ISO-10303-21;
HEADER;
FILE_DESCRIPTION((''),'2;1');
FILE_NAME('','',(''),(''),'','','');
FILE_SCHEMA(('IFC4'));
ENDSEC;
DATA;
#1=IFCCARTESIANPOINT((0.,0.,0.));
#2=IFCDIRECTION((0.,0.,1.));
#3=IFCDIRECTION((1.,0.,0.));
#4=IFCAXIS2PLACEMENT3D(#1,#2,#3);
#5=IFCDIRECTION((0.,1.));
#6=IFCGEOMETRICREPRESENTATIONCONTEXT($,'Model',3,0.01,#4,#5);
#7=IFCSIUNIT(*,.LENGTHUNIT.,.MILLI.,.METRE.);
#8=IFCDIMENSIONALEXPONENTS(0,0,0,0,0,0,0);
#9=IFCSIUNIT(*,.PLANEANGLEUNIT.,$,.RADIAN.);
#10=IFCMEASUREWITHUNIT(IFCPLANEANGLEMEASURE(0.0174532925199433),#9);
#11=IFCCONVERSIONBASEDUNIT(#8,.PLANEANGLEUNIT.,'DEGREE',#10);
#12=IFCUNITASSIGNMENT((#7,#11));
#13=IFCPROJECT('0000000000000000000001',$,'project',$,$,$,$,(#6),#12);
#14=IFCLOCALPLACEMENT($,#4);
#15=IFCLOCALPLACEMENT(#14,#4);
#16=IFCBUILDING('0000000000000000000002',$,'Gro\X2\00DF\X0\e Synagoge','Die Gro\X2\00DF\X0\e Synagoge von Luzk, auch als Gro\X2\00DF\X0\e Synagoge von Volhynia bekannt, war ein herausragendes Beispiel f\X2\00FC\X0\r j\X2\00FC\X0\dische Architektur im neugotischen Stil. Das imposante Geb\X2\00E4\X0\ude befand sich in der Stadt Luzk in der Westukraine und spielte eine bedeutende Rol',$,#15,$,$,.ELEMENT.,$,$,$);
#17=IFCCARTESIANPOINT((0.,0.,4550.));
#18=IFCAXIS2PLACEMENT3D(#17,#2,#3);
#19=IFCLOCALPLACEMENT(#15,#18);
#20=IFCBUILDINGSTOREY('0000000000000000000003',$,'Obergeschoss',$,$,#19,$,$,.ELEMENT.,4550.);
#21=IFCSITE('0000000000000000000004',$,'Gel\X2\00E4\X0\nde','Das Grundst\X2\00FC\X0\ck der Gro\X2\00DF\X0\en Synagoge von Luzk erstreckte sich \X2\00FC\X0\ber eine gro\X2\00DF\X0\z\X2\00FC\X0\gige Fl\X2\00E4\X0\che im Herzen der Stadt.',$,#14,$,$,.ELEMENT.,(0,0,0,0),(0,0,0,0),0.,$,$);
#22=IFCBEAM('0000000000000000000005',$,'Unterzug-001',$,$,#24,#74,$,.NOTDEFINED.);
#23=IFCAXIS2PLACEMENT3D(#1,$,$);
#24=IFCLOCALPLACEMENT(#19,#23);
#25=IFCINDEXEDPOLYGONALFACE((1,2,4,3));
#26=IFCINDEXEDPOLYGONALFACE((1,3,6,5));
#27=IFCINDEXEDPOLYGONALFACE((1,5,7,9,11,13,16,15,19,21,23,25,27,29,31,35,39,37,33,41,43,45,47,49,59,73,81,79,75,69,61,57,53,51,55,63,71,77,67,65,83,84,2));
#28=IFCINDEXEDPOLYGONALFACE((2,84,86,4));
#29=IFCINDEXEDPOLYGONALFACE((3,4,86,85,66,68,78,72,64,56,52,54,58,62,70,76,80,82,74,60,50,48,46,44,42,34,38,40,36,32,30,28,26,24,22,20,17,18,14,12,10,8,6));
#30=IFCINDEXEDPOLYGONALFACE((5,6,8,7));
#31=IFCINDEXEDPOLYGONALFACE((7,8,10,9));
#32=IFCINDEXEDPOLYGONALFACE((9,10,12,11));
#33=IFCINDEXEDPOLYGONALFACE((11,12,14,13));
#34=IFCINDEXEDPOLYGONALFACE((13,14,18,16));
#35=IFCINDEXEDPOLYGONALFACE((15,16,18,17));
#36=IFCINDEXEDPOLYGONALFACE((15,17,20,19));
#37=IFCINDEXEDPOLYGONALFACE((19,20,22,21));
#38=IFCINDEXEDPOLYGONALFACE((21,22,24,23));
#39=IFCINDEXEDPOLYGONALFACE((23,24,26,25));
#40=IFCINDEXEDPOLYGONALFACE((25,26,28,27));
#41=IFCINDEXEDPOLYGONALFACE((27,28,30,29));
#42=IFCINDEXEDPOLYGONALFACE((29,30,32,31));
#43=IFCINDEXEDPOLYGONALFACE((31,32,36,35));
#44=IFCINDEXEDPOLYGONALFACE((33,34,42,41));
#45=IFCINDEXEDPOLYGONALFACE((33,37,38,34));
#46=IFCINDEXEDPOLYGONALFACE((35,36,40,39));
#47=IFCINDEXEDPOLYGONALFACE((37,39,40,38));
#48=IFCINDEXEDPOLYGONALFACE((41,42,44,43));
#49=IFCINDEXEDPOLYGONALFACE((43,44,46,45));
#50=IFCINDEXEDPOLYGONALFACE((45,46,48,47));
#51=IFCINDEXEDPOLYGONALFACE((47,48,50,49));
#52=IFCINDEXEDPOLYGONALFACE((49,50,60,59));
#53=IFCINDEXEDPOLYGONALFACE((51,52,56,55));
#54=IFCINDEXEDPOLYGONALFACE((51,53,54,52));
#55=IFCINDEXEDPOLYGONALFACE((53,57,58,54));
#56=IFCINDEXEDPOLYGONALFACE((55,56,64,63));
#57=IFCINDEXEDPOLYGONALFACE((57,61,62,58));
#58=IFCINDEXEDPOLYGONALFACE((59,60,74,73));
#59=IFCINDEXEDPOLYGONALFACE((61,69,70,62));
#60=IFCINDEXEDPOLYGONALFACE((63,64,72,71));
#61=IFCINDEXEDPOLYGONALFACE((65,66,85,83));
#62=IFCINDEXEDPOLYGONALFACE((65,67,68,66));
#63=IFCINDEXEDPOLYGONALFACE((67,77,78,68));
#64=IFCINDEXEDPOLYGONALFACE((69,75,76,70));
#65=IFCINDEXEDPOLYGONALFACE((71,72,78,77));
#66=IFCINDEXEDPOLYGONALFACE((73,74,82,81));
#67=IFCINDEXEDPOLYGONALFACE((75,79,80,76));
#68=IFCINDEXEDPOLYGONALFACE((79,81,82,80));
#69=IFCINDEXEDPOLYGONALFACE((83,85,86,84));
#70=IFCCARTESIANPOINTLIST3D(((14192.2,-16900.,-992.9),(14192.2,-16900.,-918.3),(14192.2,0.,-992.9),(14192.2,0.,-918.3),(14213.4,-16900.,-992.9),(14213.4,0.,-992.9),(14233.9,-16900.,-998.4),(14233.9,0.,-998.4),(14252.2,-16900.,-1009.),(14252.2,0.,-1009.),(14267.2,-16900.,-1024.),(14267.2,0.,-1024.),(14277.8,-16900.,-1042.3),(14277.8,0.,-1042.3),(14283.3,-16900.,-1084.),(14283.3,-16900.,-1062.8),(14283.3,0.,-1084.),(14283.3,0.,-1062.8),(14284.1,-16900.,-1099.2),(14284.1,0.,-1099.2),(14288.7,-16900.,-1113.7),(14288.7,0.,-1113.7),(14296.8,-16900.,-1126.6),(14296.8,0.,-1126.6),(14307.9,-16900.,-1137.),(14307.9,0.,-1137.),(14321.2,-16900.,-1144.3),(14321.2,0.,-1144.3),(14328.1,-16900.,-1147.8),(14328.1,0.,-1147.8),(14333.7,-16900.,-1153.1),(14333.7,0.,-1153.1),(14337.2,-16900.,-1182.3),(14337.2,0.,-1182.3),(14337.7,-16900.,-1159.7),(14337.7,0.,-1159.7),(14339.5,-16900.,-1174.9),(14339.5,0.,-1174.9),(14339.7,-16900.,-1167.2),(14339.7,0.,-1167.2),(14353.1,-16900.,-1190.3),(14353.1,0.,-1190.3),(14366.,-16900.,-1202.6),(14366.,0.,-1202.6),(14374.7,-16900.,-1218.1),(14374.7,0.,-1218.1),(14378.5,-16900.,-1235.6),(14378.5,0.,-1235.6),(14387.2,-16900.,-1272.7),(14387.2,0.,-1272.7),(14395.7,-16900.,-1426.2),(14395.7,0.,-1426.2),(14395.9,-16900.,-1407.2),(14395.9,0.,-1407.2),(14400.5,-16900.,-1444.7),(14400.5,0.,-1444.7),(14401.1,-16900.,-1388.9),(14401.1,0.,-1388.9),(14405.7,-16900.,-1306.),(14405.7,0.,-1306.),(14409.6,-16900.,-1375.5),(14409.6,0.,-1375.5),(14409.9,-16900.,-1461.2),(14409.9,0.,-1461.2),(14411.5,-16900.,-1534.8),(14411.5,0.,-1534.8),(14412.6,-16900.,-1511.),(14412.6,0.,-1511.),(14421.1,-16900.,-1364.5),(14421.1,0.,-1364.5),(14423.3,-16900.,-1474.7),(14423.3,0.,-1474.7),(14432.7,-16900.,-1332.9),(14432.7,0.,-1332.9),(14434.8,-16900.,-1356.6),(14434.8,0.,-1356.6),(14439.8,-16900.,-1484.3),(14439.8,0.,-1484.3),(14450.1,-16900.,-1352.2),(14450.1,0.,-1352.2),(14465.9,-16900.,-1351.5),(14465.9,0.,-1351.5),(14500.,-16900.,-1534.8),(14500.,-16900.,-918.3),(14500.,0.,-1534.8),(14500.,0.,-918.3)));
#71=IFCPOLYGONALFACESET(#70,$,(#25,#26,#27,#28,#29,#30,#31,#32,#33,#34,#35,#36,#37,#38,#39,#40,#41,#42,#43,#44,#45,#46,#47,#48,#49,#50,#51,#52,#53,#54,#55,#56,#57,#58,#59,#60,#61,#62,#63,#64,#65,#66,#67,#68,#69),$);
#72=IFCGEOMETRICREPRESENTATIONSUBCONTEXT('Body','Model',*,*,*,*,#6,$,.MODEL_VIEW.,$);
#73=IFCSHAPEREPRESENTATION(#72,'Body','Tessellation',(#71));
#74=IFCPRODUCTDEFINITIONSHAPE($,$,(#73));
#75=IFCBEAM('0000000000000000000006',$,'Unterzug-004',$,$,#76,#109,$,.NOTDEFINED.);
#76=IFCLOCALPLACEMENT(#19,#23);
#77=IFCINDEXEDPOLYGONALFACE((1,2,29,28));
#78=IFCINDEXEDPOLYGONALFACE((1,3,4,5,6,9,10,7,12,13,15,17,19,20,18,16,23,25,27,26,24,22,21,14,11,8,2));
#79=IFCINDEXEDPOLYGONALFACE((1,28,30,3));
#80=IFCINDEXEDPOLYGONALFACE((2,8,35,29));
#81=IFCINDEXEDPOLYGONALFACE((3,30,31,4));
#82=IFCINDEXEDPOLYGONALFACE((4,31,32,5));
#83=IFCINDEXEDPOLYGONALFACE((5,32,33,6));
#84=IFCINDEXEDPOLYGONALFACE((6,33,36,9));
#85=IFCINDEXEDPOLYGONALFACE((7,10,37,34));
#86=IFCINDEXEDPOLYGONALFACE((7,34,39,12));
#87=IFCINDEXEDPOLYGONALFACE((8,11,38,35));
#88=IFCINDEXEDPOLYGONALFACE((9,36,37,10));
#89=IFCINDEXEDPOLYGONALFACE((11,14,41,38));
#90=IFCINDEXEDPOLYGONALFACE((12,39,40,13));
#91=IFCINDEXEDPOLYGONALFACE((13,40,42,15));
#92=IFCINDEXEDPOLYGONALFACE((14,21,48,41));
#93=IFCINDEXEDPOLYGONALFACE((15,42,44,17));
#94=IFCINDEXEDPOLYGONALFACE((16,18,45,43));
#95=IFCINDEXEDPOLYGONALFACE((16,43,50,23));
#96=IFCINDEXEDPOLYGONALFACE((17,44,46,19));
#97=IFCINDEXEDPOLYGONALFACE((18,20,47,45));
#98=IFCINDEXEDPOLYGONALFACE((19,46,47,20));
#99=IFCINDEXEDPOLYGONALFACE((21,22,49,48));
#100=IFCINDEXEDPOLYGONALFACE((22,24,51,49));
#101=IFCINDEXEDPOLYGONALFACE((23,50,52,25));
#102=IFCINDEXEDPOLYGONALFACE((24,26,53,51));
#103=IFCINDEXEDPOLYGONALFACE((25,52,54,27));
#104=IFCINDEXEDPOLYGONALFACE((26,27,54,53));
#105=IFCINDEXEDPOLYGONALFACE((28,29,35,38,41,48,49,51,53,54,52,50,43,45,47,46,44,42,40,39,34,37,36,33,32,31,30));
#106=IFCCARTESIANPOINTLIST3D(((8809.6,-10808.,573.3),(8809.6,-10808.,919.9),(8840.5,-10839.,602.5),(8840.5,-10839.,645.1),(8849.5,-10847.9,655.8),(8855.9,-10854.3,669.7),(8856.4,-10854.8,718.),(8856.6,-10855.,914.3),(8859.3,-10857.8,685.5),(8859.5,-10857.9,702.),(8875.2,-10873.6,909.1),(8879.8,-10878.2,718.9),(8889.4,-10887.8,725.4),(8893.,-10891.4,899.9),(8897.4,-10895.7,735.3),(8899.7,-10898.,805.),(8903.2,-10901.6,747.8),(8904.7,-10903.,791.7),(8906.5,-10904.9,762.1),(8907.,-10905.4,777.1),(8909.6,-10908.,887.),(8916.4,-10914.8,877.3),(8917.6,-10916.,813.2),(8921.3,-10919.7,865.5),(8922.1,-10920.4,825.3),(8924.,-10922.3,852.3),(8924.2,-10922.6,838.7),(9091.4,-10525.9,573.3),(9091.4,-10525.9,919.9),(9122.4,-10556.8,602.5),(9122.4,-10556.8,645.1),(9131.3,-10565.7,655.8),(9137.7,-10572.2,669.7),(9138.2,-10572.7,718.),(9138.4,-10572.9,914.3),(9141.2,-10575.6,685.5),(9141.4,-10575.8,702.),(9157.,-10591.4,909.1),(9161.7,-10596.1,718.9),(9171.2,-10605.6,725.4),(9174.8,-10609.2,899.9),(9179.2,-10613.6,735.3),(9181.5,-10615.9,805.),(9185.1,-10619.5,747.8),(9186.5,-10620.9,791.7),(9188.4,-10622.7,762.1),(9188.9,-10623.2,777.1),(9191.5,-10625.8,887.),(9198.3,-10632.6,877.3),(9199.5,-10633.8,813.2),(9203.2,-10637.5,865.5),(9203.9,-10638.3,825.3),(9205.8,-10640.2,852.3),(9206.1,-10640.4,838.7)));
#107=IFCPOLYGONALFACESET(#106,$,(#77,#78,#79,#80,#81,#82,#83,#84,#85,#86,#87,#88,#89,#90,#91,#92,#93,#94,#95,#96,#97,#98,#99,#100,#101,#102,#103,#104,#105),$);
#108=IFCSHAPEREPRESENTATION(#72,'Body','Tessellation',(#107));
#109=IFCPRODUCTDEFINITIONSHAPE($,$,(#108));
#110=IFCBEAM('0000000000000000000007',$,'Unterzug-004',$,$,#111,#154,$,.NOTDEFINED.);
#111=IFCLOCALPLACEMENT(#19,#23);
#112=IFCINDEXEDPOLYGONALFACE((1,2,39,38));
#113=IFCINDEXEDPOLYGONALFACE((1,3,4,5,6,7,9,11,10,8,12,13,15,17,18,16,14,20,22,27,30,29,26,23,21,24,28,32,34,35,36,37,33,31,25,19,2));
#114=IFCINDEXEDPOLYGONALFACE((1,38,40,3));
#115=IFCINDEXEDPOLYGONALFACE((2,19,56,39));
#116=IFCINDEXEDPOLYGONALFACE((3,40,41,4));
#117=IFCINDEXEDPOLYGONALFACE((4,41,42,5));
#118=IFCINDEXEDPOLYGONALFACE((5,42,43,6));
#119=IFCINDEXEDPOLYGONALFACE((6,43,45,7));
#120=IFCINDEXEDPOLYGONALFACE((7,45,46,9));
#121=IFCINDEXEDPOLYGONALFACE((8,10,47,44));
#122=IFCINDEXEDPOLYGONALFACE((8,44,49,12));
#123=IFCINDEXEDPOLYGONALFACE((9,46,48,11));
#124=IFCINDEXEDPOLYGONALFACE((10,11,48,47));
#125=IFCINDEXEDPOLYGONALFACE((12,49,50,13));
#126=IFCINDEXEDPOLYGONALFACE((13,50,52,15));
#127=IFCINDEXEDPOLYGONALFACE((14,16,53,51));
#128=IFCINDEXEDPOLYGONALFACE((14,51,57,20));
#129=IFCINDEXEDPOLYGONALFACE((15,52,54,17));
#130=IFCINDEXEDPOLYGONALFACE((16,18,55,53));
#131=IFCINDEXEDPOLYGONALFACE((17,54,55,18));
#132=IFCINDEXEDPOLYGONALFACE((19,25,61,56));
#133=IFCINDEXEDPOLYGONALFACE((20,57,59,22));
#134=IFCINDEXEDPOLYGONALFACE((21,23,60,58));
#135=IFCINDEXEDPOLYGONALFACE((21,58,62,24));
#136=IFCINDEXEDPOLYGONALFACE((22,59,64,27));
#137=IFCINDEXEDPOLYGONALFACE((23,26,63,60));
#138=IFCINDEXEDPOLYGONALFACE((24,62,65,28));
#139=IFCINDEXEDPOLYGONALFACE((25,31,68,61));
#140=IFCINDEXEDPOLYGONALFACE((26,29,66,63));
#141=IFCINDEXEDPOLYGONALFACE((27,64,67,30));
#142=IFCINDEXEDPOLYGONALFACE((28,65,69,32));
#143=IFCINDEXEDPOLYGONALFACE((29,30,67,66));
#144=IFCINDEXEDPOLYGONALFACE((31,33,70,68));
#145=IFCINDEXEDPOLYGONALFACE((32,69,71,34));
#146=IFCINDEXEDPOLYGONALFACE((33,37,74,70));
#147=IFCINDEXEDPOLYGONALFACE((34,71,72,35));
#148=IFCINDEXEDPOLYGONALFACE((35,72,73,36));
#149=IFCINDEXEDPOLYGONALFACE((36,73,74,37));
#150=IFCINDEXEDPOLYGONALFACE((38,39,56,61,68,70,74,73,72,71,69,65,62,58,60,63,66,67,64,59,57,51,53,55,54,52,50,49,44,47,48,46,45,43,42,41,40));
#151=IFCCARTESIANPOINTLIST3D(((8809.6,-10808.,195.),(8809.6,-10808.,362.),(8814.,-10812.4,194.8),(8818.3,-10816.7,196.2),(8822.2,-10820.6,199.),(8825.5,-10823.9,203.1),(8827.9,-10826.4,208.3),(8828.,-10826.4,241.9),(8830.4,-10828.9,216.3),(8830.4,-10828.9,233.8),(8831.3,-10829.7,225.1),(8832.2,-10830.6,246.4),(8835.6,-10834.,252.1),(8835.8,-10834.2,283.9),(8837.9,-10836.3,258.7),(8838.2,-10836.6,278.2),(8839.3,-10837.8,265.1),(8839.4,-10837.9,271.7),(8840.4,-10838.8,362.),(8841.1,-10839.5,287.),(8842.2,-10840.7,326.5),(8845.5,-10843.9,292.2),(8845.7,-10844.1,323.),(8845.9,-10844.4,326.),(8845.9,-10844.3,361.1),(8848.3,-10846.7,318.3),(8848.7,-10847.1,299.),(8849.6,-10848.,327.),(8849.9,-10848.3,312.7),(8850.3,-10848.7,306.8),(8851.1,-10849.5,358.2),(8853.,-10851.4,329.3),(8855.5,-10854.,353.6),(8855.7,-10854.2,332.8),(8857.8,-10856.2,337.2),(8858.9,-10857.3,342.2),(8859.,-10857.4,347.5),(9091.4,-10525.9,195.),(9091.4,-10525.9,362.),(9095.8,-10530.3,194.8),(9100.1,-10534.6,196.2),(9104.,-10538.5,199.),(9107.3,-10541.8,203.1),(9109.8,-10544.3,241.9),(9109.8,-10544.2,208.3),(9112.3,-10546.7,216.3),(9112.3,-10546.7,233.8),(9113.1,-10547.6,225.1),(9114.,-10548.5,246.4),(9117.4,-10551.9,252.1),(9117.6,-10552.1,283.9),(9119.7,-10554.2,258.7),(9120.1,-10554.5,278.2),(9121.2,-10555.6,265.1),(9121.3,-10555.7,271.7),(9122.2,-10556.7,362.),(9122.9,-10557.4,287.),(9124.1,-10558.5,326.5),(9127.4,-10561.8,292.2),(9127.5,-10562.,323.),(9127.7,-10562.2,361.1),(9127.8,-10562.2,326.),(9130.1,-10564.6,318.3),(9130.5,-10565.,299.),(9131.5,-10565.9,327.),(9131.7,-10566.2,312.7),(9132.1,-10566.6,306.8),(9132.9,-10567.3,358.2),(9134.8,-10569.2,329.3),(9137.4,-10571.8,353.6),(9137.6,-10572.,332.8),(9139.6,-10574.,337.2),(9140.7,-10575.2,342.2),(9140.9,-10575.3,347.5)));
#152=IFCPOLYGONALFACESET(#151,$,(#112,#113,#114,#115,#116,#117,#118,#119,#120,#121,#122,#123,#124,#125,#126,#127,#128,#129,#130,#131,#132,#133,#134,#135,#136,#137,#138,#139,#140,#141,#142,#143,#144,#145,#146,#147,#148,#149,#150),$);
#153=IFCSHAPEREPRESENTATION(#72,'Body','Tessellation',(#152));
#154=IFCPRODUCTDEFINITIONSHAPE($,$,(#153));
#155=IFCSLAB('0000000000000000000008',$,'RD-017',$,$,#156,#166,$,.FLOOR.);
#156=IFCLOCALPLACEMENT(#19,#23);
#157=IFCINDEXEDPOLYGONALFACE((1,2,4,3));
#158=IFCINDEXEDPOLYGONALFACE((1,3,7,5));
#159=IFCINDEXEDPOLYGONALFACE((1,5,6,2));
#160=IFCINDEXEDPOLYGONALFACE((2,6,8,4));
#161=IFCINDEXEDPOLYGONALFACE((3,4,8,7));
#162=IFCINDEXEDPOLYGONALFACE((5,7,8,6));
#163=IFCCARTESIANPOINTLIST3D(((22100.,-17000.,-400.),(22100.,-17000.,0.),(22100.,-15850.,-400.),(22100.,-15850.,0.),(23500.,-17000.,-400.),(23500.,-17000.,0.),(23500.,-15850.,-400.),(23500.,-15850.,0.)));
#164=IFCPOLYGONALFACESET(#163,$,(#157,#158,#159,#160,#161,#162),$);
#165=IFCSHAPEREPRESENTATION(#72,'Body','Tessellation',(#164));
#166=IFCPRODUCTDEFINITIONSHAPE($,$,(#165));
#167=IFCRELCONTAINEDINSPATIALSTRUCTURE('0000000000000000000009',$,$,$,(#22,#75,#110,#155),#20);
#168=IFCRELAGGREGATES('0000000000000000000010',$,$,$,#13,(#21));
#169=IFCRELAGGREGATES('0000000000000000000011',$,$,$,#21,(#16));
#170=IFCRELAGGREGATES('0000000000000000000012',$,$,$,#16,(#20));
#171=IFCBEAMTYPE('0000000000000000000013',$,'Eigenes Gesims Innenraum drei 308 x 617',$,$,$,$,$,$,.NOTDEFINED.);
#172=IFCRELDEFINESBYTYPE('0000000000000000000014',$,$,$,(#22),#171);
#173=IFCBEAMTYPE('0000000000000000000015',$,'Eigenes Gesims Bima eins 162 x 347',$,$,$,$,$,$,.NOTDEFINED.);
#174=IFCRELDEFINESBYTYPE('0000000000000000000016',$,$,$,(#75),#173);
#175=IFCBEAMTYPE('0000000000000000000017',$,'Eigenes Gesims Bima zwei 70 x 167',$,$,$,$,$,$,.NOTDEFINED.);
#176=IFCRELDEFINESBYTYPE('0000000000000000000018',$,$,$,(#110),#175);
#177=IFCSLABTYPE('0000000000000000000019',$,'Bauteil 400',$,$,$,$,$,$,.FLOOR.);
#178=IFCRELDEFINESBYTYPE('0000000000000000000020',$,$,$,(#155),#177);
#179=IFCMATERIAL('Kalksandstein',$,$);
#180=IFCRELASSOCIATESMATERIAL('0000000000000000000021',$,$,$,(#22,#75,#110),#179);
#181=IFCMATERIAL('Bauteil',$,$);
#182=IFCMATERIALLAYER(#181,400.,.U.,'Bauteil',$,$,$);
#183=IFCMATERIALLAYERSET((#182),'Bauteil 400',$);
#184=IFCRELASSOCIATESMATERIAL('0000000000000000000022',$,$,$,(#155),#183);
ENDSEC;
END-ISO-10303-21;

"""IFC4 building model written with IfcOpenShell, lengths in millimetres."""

from ifc_helpers import new_model, entity, si_unit, converted_unit, direction, frame, origin_with_axes, place, context, subcontext, project, spatial, line, arc, indexed_curve, outline, extrude, material, layer, layer_set, layer_usage, material_profile, profile_set, type_object, element, save


model = new_model("IFC4")

# Units and contexts
model_context = context("Model", 3, precision=0.01, world=origin_with_axes(), true_north=direction((0.0, 1.0)))
body_context = subcontext(model_context, "Body", "Model", "MODEL_VIEW")
ifc_project = project(units=[si_unit("LENGTHUNIT", "METRE", prefix="MILLI"), converted_unit("PLANEANGLEUNIT", "DEGREE", entity("IfcPlaneAngleMeasure", 0.0174532925199433), si_unit("PLANEANGLEUNIT", "RADIAN"), dimensions=[0, 0, 0, 0, 0, 0, 0])], contexts=[model_context])

# Site, building, storey
site_placement = place(None, origin_with_axes())
site = spatial("IfcSite", under=ifc_project, at=site_placement, Name="Gelände", Description="Das Grundstück der Großen Synagoge von Luzk erstreckte sich über eine großzügige Fläche im Herzen der Stadt.", CompositionType="ELEMENT", RefLatitude=(0, 0, 0, 0), RefLongitude=(0, 0, 0, 0), RefElevation=0.0)
building_placement = place(site_placement, origin_with_axes())
building = spatial("IfcBuilding", under=site, at=building_placement, Name="Große Synagoge", Description="Die Große Synagoge von Luzk, auch als Große Synagoge von Volhynia bekannt, war ein herausragendes Beispiel für jüdische Architektur im neugotischen Stil. Das imposante Gebäude befand sich in der Stadt Luzk in der Westukraine und spielte eine bedeutende Rol", CompositionType="ELEMENT")
storey_placement = place(building_placement, frame((0.0, 0.0, 4550.0), z_axis=(0.0, 0.0, 1.0), x_axis=(1.0, 0.0, 0.0)))
storey = spatial("IfcBuildingStorey", under=building, at=storey_placement, Name="Obergeschoss", CompositionType="ELEMENT", Elevation=4550.0)

# Beams
ifc_material_1 = material(Name="Kalksandstein")
ifc_material_profile_1 = material_profile(ifc_material_1, outline(indexed_curve([(121.5, -317.3), (134.0, -284.3), (162.8, -264.0), (162.3, -241.4), (178.8, -226.0), (207.7, -202.1), (216.7, -165.7), (239.8, -97.7), (307.8, -74.6), (307.8, 0.0), (0.0, 0.0), (0.0, -616.6), (88.5, -616.6), (87.4, -592.7), (60.2, -566.0), (99.5, -526.4), (98.9, -470.6), (72.3, -441.9), (34.1, -433.2), (94.3, -387.7)], segments=[arc(1, 2, 3), arc(3, 4, 5), arc(5, 6, 7), arc(7, 8, 9), line(9, 10, 11, 12, 13, 14, 15), arc(15, 16, 17), arc(17, 18, 19), arc(19, 20, 1)])), Name="Kalksandstein")
ifc_profile_set_1 = profile_set([ifc_material_profile_1], Name="Eigenes Gesims Innenraum drei")
beam_type_1 = type_object("IfcBeamType", Name="Eigenes Gesims Innenraum drei 308 x 617", PredefinedType="NOTDEFINED")
beam_1_placement = place(storey_placement, frame((14500.0, -16900.0, -918.3), z_axis=(0.0, 0.0, 1.0), x_axis=(1.0, 0.0, 0.0)))
element("IfcBeam", 1, at=beam_1_placement, inside=storey, type_object=beam_type_1, material=ifc_profile_set_1, Name="Unterzug-001", PredefinedType="NOTDEFINED", context=body_context, shape_type="SweptSolid", body=[
    extrude(outline(indexed_curve([(121.5, -317.3), (134.0, -284.3), (162.8, -264.0), (162.3, -241.4), (178.8, -226.0), (207.7, -202.1), (216.7, -165.7), (239.8, -97.7), (307.8, -74.6), (307.8, 0.0), (0.0, 0.0), (0.0, -616.6), (88.5, -616.6), (87.4, -592.7), (60.2, -566.0), (99.5, -526.4), (98.9, -470.6), (72.3, -441.9), (34.1, -433.2), (94.3, -387.7)], segments=[arc(1, 2, 3), arc(3, 4, 5), arc(5, 6, 7), arc(7, 8, 9), line(9, 10, 11, 12, 13, 14, 15), arc(15, 16, 17), arc(17, 18, 19), arc(19, 20, 1)])), frame((0.0, 16900.0, 0.0), z_axis=(0.0, 1.0, 0.0), x_axis=(-1.0, 0.0, 0.0)), (0.0, 0.0, -1.0), 16900.0),
])
ifc_material_profile_2 = material_profile(ifc_material_1, outline(indexed_curve([(127.4, -114.9), (152.7, -106.7), (161.7, -67.6), (141.4, -32.9), (105.5, -14.9), (66.5, -5.6), (0.0, 0.0), (0.0, -346.6), (43.7, -317.4), (43.7, -274.8), (68.5, -242.5), (66.2, -201.9), (99.3, -201.0), (135.2, -165.1)], segments=[line(1, 2), arc(2, 3, 4), arc(4, 5, 6), line(6, 7, 8, 9, 10), arc(10, 11, 12), line(12, 13), arc(13, 14, 1)])), Name="Kalksandstein")
ifc_profile_set_2 = profile_set([ifc_material_profile_2], Name="Eigenes Gesims Bima eins")
beam_type_2 = type_object("IfcBeamType", Name="Eigenes Gesims Bima eins 162 x 347", PredefinedType="NOTDEFINED")
beam_2_placement = place(storey_placement, frame((8809.6, -10808.0, 919.9), z_axis=(0.0, 0.0, 1.0), x_axis=(0.707468, -0.706745, 0.0)))
element("IfcBeam", 2, at=beam_2_placement, inside=storey, type_object=beam_type_2, material=ifc_profile_set_2, Name="Unterzug-004", PredefinedType="NOTDEFINED", context=body_context, shape_type="SweptSolid", body=[
    extrude(outline(indexed_curve([(127.4, -114.9), (152.7, -106.7), (161.7, -67.6), (141.4, -32.9), (105.5, -14.9), (66.5, -5.6), (0.0, 0.0), (0.0, -346.6), (43.7, -317.4), (43.7, -274.8), (68.5, -242.5), (66.2, -201.9), (99.3, -201.0), (135.2, -165.1)], segments=[line(1, 2), arc(2, 3, 4), arc(4, 5, 6), line(6, 7, 8, 9, 10), arc(10, 11, 12), line(12, 13), arc(13, 14, 1)])), frame((0.0, 398.8, 0.0), z_axis=(0.0, -1.0, 0.0), x_axis=(1.0, 0.0, 0.0)), (0.0, 0.0, 1.0), 398.8),
])
ifc_material_profile_3 = material_profile(ifc_material_1, outline(indexed_curve([(40.0, -103.3), (42.2, -90.2), (37.0, -78.1), (50.8, -69.8), (57.6, -55.2), (54.7, -43.7), (46.2, -35.5), (63.4, -31.1), (69.9, -14.5), (58.6, -3.7), (43.5, 0.0), (0.0, 0.0), (0.0, -167.0), (15.1, -164.6), (26.0, -153.7), (30.7, -136.9), (26.0, -120.0), (34.5, -112.9)], segments=[arc(1, 2, 3), arc(3, 4, 5), arc(5, 6, 7), arc(7, 8, 9), arc(9, 10, 11), line(11, 12, 13), arc(13, 14, 15), arc(15, 16, 17), arc(17, 18, 1)])), Name="Kalksandstein")
ifc_profile_set_3 = profile_set([ifc_material_profile_3], Name="Eigenes Gesims Bima zwei")
beam_type_3 = type_object("IfcBeamType", Name="Eigenes Gesims Bima zwei 70 x 167", PredefinedType="NOTDEFINED")
beam_3_placement = place(storey_placement, frame((8809.6, -10808.0, 362.0), z_axis=(0.0, 0.0, 1.0), x_axis=(0.707468, -0.706745, 0.0)))
element("IfcBeam", 3, at=beam_3_placement, inside=storey, type_object=beam_type_3, material=ifc_profile_set_3, Name="Unterzug-004", PredefinedType="NOTDEFINED", context=body_context, shape_type="SweptSolid", body=[
    extrude(outline(indexed_curve([(40.0, -103.3), (42.2, -90.2), (37.0, -78.1), (50.8, -69.8), (57.6, -55.2), (54.7, -43.7), (46.2, -35.5), (63.4, -31.1), (69.9, -14.5), (58.6, -3.7), (43.5, 0.0), (0.0, 0.0), (0.0, -167.0), (15.1, -164.6), (26.0, -153.7), (30.7, -136.9), (26.0, -120.0), (34.5, -112.9)], segments=[arc(1, 2, 3), arc(3, 4, 5), arc(5, 6, 7), arc(7, 8, 9), arc(9, 10, 11), line(11, 12, 13), arc(13, 14, 15), arc(15, 16, 17), arc(17, 18, 1)])), frame((0.0, 398.8, 0.0), z_axis=(0.0, -1.0, 0.0), x_axis=(1.0, 0.0, 0.0)), (0.0, 0.0, 1.0), 398.8),
])

# Slab
ifc_material_2 = material(Name="Bauteil")
ifc_layer_1 = layer(ifc_material_2, 400.0, ventilated="UNKNOWN", Name="Bauteil")
ifc_layer_set_1 = layer_set([ifc_layer_1], Name="Bauteil 400")
ifc_layer_usage_1 = layer_usage(ifc_layer_set_1, "AXIS3", "NEGATIVE", 400.0)
slab_type_1 = type_object("IfcSlabType", Name="Bauteil 400", PredefinedType="FLOOR")
slab_1_placement = place(storey_placement, frame((22100.0, -17000.0, 0.0), z_axis=(0.0, 0.0, 1.0), x_axis=(1.0, 0.0, 0.0)))
element("IfcSlab", 4, at=slab_1_placement, inside=storey, type_object=slab_type_1, material=ifc_layer_usage_1, Name="RD-017", PredefinedType="FLOOR", context=body_context, shape_type="SweptSolid", body=[
    extrude(outline(indexed_curve([(0.0, 0.0), (1400.0, 0.0), (1400.0, 1150.0), (0.0, 1150.0)], segments=[line(1, 2, 3, 4, 1)])), frame((0.0, 0.0, -400.0), z_axis=(0.0, 0.0, 1.0), x_axis=(1.0, 0.0, 0.0)), (0.0, 0.0, 1.0), 400.0),
])

save(model, "model.ifc")
